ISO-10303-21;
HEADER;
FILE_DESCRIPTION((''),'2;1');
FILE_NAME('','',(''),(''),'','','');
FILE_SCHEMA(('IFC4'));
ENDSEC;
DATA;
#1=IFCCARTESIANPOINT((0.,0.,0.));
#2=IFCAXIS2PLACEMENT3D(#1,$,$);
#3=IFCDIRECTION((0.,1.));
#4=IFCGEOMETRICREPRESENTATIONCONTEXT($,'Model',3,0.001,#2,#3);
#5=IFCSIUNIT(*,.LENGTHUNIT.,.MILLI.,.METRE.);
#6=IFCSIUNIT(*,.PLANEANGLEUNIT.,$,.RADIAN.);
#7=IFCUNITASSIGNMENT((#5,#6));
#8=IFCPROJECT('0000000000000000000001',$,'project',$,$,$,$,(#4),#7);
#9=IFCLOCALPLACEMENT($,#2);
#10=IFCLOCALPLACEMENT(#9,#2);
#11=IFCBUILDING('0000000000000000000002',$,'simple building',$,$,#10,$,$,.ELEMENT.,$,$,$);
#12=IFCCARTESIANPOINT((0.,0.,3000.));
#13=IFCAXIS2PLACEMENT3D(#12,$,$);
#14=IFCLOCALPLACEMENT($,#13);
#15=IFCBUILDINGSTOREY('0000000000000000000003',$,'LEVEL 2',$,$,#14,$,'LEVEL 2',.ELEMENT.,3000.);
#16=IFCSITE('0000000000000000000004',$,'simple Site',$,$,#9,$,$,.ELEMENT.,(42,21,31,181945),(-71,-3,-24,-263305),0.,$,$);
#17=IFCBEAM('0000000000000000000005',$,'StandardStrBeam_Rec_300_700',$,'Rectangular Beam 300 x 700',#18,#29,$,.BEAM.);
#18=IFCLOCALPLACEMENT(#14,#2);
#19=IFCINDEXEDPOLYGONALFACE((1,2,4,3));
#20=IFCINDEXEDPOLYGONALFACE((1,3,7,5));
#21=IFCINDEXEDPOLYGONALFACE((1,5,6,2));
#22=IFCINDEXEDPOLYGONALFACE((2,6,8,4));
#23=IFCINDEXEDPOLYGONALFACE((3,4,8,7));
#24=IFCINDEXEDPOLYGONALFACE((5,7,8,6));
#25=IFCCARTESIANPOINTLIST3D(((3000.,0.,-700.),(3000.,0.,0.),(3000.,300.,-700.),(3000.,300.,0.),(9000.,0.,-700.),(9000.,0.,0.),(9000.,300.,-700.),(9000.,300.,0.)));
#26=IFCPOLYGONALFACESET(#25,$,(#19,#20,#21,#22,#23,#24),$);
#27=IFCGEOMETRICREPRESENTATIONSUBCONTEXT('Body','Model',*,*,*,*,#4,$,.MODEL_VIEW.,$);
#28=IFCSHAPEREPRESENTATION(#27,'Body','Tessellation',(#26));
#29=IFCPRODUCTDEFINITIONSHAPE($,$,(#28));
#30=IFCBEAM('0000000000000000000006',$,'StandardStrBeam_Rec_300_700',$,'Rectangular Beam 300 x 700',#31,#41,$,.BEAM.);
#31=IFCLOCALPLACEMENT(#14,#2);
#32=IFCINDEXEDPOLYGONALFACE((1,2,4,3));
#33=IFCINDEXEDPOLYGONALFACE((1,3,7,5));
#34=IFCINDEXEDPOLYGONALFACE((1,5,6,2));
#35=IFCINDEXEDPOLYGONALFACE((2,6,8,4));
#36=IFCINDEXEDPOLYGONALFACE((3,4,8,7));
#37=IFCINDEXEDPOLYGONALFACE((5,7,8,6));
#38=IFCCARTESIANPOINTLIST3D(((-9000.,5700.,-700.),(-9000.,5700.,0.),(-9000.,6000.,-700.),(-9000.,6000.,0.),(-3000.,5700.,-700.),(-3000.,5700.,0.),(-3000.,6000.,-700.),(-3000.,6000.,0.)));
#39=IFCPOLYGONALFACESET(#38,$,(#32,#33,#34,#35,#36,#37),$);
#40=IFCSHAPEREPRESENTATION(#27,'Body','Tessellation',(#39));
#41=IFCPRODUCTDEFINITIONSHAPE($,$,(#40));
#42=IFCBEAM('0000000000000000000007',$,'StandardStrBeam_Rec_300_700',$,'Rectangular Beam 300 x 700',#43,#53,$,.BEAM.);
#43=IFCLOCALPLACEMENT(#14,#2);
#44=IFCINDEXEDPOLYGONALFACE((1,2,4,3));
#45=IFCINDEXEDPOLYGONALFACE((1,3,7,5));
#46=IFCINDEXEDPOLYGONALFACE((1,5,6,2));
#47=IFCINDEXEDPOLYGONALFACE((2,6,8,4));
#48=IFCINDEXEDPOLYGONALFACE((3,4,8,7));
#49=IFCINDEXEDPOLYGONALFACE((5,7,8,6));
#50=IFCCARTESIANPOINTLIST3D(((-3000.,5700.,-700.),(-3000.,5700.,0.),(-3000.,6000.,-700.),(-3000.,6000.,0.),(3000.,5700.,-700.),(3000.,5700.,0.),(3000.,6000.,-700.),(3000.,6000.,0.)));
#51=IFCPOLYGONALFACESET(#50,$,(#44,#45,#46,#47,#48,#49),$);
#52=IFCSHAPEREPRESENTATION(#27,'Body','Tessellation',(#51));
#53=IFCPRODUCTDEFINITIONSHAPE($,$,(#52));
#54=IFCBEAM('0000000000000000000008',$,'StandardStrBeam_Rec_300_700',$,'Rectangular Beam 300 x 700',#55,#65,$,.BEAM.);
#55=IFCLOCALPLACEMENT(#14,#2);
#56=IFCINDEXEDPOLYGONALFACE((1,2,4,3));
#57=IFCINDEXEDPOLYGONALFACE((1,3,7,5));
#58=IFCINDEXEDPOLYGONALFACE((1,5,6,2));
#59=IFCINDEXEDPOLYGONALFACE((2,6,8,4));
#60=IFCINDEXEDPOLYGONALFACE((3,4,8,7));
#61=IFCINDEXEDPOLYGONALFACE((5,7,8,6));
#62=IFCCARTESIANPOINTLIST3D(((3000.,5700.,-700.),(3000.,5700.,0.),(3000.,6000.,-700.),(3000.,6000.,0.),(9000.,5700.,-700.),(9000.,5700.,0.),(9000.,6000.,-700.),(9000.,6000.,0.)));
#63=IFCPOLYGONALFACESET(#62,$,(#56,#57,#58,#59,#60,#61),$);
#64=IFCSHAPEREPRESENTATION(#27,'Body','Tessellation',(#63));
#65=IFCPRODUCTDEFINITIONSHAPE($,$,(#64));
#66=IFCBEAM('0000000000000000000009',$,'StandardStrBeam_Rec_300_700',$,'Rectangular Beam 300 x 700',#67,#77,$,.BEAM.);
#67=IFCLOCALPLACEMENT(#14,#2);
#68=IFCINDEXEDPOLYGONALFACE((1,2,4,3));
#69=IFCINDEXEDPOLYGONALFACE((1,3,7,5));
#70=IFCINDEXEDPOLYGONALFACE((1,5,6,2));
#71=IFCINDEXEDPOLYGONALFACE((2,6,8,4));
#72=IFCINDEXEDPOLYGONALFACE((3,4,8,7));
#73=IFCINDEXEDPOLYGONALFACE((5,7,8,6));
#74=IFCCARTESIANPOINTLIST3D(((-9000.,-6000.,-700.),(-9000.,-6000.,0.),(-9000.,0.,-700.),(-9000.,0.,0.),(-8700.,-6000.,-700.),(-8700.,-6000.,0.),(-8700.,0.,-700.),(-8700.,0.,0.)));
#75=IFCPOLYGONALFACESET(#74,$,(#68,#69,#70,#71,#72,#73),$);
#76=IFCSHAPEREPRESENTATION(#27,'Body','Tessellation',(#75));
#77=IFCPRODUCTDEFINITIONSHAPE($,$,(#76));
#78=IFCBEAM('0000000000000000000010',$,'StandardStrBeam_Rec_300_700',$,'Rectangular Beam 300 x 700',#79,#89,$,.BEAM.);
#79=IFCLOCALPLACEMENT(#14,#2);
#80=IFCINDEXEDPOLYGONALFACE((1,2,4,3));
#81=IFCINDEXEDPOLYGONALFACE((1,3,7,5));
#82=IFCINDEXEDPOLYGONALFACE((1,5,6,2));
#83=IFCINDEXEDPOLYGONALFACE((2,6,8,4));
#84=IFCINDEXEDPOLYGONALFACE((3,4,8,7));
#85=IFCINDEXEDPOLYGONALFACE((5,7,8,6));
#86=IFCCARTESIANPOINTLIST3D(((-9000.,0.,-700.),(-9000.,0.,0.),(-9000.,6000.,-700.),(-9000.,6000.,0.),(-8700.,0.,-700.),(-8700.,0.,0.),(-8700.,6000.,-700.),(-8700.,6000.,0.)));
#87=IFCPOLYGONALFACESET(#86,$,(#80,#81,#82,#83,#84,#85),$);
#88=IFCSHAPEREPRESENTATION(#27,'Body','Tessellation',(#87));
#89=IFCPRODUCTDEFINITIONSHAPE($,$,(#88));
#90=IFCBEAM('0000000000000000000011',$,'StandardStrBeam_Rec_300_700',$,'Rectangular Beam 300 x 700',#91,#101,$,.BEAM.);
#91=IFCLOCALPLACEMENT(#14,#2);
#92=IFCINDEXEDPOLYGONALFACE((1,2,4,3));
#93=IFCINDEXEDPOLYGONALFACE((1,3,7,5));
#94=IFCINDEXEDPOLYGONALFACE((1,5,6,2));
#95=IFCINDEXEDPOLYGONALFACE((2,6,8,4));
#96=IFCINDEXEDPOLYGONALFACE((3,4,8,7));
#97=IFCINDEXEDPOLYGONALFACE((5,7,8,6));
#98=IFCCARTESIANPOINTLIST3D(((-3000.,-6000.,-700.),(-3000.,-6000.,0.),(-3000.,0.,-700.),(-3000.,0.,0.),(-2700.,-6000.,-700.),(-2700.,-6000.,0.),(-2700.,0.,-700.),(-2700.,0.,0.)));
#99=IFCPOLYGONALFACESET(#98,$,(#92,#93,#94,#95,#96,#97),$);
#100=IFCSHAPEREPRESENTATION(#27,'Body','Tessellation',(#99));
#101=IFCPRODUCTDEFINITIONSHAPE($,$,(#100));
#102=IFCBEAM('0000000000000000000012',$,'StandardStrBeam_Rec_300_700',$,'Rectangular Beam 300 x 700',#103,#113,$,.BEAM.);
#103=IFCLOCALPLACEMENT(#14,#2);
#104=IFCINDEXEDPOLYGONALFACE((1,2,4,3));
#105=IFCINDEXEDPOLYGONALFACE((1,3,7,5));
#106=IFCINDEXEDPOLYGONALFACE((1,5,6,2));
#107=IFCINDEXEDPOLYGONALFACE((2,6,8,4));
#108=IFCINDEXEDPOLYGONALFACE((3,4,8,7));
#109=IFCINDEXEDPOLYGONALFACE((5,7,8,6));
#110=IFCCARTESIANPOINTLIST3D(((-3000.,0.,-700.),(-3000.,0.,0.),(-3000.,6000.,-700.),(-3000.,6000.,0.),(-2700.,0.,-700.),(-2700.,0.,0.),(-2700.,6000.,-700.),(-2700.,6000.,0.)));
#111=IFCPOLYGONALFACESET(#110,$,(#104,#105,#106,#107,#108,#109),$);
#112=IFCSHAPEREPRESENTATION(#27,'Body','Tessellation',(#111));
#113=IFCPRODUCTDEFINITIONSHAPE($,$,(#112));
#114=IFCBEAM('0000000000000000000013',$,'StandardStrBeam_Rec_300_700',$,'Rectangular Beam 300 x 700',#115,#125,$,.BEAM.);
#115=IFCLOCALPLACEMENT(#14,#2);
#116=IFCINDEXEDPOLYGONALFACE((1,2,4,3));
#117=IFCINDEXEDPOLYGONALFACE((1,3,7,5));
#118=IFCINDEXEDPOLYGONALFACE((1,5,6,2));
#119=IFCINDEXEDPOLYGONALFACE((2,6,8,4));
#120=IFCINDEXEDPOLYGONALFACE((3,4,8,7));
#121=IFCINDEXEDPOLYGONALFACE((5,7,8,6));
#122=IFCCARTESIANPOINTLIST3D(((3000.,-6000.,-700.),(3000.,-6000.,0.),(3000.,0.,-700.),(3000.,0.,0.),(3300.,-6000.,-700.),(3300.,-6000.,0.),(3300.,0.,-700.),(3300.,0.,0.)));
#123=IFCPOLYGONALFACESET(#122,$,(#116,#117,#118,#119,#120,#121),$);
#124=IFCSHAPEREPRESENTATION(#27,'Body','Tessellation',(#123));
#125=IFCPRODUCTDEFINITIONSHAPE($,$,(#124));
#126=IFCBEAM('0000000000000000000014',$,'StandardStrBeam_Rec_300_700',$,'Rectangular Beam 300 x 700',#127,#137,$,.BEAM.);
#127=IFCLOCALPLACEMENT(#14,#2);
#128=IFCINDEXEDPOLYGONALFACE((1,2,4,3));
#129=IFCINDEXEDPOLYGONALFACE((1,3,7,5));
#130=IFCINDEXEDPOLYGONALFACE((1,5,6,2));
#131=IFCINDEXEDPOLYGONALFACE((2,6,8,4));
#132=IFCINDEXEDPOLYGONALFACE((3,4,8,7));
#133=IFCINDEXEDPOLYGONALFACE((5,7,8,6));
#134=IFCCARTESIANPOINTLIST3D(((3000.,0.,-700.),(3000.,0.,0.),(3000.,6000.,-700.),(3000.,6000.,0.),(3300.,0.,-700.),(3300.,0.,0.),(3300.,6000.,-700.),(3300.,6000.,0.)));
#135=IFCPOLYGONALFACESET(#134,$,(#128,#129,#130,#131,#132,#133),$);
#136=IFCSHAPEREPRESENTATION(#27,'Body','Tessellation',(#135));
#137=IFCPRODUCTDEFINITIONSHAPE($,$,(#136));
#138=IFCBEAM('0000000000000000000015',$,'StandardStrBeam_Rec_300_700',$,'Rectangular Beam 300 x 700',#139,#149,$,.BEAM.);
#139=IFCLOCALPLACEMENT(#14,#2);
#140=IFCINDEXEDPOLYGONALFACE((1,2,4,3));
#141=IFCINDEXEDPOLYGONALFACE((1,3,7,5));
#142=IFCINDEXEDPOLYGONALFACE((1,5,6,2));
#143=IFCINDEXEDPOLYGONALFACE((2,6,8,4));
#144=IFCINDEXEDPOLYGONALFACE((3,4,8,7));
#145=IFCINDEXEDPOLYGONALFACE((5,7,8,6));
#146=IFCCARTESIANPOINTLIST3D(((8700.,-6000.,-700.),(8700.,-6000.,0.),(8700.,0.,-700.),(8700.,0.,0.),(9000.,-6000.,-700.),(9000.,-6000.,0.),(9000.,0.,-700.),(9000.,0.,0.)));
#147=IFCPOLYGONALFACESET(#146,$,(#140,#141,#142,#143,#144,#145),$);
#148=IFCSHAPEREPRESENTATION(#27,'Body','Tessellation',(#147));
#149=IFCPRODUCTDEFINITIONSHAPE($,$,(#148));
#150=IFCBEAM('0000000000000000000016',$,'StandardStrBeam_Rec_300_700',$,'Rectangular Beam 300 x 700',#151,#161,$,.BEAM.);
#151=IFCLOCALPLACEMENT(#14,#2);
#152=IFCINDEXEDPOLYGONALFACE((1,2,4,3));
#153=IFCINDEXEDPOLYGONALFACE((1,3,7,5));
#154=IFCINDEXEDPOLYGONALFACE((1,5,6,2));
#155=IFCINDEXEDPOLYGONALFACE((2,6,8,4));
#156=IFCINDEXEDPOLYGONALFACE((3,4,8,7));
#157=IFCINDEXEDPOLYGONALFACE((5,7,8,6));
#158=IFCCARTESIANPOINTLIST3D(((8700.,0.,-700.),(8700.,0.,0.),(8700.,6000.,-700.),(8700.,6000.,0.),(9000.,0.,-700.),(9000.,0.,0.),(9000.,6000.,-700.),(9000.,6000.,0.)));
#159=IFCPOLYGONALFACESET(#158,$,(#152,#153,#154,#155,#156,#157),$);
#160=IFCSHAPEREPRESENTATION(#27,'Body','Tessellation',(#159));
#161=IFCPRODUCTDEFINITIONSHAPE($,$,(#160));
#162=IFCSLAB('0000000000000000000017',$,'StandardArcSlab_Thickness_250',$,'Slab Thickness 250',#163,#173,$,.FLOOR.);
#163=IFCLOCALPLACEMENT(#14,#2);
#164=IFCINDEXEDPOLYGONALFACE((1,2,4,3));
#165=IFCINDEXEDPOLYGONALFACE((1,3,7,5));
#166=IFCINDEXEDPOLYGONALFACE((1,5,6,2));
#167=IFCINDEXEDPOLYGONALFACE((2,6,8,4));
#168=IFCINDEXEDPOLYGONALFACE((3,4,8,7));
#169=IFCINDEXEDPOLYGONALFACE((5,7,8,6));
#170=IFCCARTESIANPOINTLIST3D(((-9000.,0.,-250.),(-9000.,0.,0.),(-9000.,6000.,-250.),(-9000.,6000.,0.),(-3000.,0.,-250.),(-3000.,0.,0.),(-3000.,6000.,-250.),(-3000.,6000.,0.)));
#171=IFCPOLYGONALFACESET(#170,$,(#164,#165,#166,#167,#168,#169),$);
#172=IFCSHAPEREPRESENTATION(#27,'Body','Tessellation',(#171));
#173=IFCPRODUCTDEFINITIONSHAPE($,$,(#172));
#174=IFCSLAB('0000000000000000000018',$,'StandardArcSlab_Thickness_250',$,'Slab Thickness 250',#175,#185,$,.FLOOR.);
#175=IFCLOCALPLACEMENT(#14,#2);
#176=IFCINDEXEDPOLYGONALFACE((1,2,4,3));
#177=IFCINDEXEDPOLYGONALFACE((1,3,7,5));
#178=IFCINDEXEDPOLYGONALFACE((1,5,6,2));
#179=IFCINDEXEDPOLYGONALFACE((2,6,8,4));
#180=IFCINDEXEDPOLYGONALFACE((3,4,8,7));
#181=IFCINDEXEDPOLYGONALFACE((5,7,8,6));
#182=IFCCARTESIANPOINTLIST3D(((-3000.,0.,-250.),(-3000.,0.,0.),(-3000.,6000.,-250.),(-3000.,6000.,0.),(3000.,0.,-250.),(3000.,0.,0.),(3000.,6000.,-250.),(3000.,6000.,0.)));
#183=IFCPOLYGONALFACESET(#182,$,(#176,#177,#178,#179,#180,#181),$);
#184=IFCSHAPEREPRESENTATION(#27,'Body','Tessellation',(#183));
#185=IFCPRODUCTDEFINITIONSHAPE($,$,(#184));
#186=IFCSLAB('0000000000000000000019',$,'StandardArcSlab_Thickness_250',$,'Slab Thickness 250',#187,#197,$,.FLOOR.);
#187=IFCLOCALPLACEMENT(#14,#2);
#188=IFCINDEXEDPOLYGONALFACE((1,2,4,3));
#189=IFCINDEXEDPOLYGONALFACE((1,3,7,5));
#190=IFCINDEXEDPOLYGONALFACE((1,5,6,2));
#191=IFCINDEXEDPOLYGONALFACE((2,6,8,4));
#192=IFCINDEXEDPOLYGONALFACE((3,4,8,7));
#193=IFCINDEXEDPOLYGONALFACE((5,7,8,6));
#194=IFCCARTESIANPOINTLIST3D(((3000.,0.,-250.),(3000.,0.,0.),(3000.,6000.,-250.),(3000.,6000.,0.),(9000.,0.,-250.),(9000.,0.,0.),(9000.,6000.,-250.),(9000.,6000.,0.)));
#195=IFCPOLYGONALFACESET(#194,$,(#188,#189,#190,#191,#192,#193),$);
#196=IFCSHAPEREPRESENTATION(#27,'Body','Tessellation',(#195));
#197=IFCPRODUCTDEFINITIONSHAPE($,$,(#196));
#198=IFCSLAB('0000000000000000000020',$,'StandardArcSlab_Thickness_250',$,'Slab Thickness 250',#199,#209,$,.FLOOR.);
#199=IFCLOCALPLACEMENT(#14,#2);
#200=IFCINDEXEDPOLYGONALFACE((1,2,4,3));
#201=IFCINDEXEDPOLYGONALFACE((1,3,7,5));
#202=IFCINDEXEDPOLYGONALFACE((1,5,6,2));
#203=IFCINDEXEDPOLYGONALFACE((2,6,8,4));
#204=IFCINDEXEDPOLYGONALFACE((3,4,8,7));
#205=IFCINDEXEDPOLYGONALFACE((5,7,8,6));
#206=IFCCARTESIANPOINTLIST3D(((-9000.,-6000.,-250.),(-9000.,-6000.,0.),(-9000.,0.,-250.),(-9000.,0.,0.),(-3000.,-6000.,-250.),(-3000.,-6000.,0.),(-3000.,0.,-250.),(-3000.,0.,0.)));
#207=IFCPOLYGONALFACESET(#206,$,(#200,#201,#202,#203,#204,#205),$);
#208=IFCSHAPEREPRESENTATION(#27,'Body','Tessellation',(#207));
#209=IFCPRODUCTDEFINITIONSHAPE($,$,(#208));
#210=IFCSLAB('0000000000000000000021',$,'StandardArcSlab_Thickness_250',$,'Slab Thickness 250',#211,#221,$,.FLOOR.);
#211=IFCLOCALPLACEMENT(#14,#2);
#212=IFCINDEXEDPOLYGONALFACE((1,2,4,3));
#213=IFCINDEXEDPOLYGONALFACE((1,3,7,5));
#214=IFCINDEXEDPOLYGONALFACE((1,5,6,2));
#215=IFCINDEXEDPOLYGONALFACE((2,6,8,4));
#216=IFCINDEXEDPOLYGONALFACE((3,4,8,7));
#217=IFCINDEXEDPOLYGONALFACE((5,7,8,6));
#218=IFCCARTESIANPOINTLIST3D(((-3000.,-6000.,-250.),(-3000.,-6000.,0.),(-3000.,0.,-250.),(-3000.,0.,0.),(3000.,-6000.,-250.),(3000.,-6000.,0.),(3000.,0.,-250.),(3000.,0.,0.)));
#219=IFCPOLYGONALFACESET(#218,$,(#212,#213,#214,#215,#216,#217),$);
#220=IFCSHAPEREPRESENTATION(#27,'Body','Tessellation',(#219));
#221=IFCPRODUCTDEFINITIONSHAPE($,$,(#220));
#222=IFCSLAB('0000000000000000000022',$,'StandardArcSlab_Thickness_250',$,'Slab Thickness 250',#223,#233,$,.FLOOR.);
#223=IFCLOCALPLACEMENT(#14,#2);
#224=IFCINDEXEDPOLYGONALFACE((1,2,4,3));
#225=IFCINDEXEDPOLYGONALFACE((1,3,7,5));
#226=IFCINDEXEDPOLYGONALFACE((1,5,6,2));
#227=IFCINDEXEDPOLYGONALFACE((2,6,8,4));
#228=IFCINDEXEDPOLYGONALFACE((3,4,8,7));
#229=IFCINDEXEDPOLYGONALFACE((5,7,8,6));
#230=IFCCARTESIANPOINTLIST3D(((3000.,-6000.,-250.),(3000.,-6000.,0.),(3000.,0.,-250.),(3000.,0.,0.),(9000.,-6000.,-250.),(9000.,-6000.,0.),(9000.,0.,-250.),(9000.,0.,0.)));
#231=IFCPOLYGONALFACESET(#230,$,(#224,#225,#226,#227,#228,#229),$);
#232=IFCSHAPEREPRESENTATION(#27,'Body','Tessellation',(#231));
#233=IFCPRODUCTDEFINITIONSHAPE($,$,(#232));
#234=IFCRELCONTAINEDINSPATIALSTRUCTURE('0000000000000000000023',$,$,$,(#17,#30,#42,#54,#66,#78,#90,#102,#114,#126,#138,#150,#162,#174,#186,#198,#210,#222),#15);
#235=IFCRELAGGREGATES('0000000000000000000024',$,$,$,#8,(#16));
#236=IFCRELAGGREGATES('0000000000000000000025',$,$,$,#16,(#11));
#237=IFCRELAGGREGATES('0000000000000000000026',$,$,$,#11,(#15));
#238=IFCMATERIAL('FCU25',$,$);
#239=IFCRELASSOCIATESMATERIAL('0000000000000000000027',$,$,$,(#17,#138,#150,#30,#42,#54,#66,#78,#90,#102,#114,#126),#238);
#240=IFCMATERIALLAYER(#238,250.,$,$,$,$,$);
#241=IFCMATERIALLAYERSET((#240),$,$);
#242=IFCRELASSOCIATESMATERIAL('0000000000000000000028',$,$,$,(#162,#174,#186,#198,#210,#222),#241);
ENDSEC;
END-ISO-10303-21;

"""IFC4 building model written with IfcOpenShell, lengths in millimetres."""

from ifc_helpers import new_model, si_unit, direction, frame, origin, origin_with_axes, origin_2d_with_axis, place, context, subcontext, project, spatial, polyline, rectangle, outline, extrude, material, layer, layer_set, layer_usage, material_profile, profile_set, profile_usage, element, save


model = new_model("IFC4")

# Units and contexts
model_context = context("Model", 3, precision=0.001, world=origin(), true_north=direction((0.0, 1.0)))
body_context = subcontext(model_context, "Body", "Model", "MODEL_VIEW")
ifc_project = project(units=[si_unit("LENGTHUNIT", "METRE", prefix="MILLI"), si_unit("PLANEANGLEUNIT", "RADIAN")], contexts=[model_context])

# Site, building, storey
site_placement = place(None, origin())
site = spatial("IfcSite", under=ifc_project, at=site_placement, Name="simple Site", CompositionType="ELEMENT", RefLatitude=(42, 21, 31, 181945), RefLongitude=(-71, -3, -24, -263305), RefElevation=0.0)
building_placement = place(site_placement, origin())
building = spatial("IfcBuilding", under=site, at=building_placement, Name="simple building", CompositionType="ELEMENT")
storey_placement = place(None, frame((0.0, 0.0, 3000.0)))
storey = spatial("IfcBuildingStorey", under=building, at=storey_placement, Name="LEVEL 2", LongName="LEVEL 2", CompositionType="ELEMENT", Elevation=3000.0)

# Beams
ifc_material_1 = material(Name="FCU25")
ifc_material_profile_1 = material_profile(ifc_material_1, rectangle(XDim=300.0, YDim=700.0, at=origin_2d_with_axis()))
ifc_profile_set_1 = profile_set([ifc_material_profile_1])
ifc_profile_usage_1 = profile_usage(ifc_profile_set_1, cardinal=9)
for number, where, z_axis, x_axis, name in (
    (1, (3000.0, 150.0, 2650.0), (1.0, 0.0, 0.0), (0.0, -1.0, 0.0), "StandardStrBeam_Rec_300_700"),
):
    element("IfcBeam", number, at=place(None, frame(where, z_axis=z_axis, x_axis=x_axis)), inside=storey, material=ifc_profile_usage_1, Name=name, ObjectType="Rectangular Beam 300 x 700", PredefinedType="BEAM", context=body_context, shape_type="SweptSolid", body=[
        extrude(rectangle(XDim=300.0, YDim=700.0, at=origin_2d_with_axis()), origin_with_axes(), (0.0, 0.0, 1.0), 6000.0),
    ])
ifc_profile_usage_2 = profile_usage(ifc_profile_set_1, cardinal=7)
for number, where, z_axis, x_axis, name in (
    (2, (-9000.0, 5850.0, 2650.0), (1.0, 0.0, 0.0), (0.0, -1.0, 0.0), "StandardStrBeam_Rec_300_700"),
    (3, (-3000.0, 5850.0, 2650.0), (1.0, 0.0, 0.0), (0.0, -1.0, 0.0), "StandardStrBeam_Rec_300_700"),
    (4, (3000.0, 5850.0, 2650.0), (1.0, 0.0, 0.0), (0.0, -1.0, 0.0), "StandardStrBeam_Rec_300_700"),
    (5, (-8850.0, -6000.0, 2650.0), (0.0, 1.0, 0.0), (1.0, 0.0, 0.0), "StandardStrBeam_Rec_300_700"),
    (6, (-8850.0, 0.0, 2650.0), (0.0, 1.0, 0.0), (1.0, 0.0, 0.0), "StandardStrBeam_Rec_300_700"),
    (7, (-2850.0, -6000.0, 2650.0), (0.0, 1.0, 0.0), (1.0, 0.0, 0.0), "StandardStrBeam_Rec_300_700"),
    (8, (-2850.0, 0.0, 2650.0), (0.0, 1.0, 0.0), (1.0, 0.0, 0.0), "StandardStrBeam_Rec_300_700"),
    (9, (3150.0, -6000.0, 2650.0), (0.0, 1.0, 0.0), (1.0, 0.0, 0.0), "StandardStrBeam_Rec_300_700"),
    (10, (3150.0, 0.0, 2650.0), (0.0, 1.0, 0.0), (1.0, 0.0, 0.0), "StandardStrBeam_Rec_300_700"),
):
    element("IfcBeam", number, at=place(None, frame(where, z_axis=z_axis, x_axis=x_axis)), inside=storey, material=ifc_profile_usage_2, Name=name, ObjectType="Rectangular Beam 300 x 700", PredefinedType="BEAM", context=body_context, shape_type="SweptSolid", body=[
        extrude(rectangle(XDim=300.0, YDim=700.0, at=origin_2d_with_axis()), origin_with_axes(), (0.0, 0.0, 1.0), 6000.0),
    ])
for number, where, z_axis, x_axis, name in (
    (11, (8850.0, -6000.0, 2650.0), (0.0, 1.0, 0.0), (1.0, 0.0, 0.0), "StandardStrBeam_Rec_300_700"),
    (12, (8850.0, 0.0, 2650.0), (0.0, 1.0, 0.0), (1.0, 0.0, 0.0), "StandardStrBeam_Rec_300_700"),
):
    element("IfcBeam", number, at=place(None, frame(where, z_axis=z_axis, x_axis=x_axis)), inside=storey, material=ifc_profile_usage_1, Name=name, ObjectType="Rectangular Beam 300 x 700", PredefinedType="BEAM", context=body_context, shape_type="SweptSolid", body=[
        extrude(rectangle(XDim=300.0, YDim=700.0, at=origin_2d_with_axis()), origin_with_axes(), (0.0, 0.0, 1.0), 6000.0),
    ])

# Slabs
ifc_layer = layer(ifc_material_1, 250.0)
ifc_layer_set = layer_set([ifc_layer])
ifc_layer_usage = layer_usage(ifc_layer_set, "AXIS3", "POSITIVE", -250.0)
for number, where, z_axis, x_axis, name in (
    (13, (-9000.0, 0.0, 2750.0), (0.0, 0.0, 1.0), (1.0, 0.0, 0.0), "StandardArcSlab_Thickness_250"),
    (14, (-3000.0, 0.0, 2750.0), (0.0, 0.0, 1.0), (1.0, 0.0, 0.0), "StandardArcSlab_Thickness_250"),
    (15, (3000.0, 0.0, 2750.0), (0.0, 0.0, 1.0), (1.0, 0.0, 0.0), "StandardArcSlab_Thickness_250"),
    (16, (-9000.0, -6000.0, 2750.0), (0.0, 0.0, 1.0), (1.0, 0.0, 0.0), "StandardArcSlab_Thickness_250"),
    (17, (-3000.0, -6000.0, 2750.0), (0.0, 0.0, 1.0), (1.0, 0.0, 0.0), "StandardArcSlab_Thickness_250"),
    (18, (3000.0, -6000.0, 2750.0), (0.0, 0.0, 1.0), (1.0, 0.0, 0.0), "StandardArcSlab_Thickness_250"),
):
    element("IfcSlab", number, at=place(None, frame(where, z_axis=z_axis, x_axis=x_axis)), inside=storey, material=ifc_layer_usage, Name=name, ObjectType="Slab Thickness 250", PredefinedType="FLOOR", context=body_context, shape_type="SweptSolid", body=[
        extrude(outline(polyline([(0.0, 0.0), (6000.0, 0.0), (6000.0, 6000.0), (0.0, 6000.0), (0.0, 0.0)])), origin_with_axes(), (0.0, 0.0, 1.0), 250.0),
    ])

save(model, "model.ifc")
